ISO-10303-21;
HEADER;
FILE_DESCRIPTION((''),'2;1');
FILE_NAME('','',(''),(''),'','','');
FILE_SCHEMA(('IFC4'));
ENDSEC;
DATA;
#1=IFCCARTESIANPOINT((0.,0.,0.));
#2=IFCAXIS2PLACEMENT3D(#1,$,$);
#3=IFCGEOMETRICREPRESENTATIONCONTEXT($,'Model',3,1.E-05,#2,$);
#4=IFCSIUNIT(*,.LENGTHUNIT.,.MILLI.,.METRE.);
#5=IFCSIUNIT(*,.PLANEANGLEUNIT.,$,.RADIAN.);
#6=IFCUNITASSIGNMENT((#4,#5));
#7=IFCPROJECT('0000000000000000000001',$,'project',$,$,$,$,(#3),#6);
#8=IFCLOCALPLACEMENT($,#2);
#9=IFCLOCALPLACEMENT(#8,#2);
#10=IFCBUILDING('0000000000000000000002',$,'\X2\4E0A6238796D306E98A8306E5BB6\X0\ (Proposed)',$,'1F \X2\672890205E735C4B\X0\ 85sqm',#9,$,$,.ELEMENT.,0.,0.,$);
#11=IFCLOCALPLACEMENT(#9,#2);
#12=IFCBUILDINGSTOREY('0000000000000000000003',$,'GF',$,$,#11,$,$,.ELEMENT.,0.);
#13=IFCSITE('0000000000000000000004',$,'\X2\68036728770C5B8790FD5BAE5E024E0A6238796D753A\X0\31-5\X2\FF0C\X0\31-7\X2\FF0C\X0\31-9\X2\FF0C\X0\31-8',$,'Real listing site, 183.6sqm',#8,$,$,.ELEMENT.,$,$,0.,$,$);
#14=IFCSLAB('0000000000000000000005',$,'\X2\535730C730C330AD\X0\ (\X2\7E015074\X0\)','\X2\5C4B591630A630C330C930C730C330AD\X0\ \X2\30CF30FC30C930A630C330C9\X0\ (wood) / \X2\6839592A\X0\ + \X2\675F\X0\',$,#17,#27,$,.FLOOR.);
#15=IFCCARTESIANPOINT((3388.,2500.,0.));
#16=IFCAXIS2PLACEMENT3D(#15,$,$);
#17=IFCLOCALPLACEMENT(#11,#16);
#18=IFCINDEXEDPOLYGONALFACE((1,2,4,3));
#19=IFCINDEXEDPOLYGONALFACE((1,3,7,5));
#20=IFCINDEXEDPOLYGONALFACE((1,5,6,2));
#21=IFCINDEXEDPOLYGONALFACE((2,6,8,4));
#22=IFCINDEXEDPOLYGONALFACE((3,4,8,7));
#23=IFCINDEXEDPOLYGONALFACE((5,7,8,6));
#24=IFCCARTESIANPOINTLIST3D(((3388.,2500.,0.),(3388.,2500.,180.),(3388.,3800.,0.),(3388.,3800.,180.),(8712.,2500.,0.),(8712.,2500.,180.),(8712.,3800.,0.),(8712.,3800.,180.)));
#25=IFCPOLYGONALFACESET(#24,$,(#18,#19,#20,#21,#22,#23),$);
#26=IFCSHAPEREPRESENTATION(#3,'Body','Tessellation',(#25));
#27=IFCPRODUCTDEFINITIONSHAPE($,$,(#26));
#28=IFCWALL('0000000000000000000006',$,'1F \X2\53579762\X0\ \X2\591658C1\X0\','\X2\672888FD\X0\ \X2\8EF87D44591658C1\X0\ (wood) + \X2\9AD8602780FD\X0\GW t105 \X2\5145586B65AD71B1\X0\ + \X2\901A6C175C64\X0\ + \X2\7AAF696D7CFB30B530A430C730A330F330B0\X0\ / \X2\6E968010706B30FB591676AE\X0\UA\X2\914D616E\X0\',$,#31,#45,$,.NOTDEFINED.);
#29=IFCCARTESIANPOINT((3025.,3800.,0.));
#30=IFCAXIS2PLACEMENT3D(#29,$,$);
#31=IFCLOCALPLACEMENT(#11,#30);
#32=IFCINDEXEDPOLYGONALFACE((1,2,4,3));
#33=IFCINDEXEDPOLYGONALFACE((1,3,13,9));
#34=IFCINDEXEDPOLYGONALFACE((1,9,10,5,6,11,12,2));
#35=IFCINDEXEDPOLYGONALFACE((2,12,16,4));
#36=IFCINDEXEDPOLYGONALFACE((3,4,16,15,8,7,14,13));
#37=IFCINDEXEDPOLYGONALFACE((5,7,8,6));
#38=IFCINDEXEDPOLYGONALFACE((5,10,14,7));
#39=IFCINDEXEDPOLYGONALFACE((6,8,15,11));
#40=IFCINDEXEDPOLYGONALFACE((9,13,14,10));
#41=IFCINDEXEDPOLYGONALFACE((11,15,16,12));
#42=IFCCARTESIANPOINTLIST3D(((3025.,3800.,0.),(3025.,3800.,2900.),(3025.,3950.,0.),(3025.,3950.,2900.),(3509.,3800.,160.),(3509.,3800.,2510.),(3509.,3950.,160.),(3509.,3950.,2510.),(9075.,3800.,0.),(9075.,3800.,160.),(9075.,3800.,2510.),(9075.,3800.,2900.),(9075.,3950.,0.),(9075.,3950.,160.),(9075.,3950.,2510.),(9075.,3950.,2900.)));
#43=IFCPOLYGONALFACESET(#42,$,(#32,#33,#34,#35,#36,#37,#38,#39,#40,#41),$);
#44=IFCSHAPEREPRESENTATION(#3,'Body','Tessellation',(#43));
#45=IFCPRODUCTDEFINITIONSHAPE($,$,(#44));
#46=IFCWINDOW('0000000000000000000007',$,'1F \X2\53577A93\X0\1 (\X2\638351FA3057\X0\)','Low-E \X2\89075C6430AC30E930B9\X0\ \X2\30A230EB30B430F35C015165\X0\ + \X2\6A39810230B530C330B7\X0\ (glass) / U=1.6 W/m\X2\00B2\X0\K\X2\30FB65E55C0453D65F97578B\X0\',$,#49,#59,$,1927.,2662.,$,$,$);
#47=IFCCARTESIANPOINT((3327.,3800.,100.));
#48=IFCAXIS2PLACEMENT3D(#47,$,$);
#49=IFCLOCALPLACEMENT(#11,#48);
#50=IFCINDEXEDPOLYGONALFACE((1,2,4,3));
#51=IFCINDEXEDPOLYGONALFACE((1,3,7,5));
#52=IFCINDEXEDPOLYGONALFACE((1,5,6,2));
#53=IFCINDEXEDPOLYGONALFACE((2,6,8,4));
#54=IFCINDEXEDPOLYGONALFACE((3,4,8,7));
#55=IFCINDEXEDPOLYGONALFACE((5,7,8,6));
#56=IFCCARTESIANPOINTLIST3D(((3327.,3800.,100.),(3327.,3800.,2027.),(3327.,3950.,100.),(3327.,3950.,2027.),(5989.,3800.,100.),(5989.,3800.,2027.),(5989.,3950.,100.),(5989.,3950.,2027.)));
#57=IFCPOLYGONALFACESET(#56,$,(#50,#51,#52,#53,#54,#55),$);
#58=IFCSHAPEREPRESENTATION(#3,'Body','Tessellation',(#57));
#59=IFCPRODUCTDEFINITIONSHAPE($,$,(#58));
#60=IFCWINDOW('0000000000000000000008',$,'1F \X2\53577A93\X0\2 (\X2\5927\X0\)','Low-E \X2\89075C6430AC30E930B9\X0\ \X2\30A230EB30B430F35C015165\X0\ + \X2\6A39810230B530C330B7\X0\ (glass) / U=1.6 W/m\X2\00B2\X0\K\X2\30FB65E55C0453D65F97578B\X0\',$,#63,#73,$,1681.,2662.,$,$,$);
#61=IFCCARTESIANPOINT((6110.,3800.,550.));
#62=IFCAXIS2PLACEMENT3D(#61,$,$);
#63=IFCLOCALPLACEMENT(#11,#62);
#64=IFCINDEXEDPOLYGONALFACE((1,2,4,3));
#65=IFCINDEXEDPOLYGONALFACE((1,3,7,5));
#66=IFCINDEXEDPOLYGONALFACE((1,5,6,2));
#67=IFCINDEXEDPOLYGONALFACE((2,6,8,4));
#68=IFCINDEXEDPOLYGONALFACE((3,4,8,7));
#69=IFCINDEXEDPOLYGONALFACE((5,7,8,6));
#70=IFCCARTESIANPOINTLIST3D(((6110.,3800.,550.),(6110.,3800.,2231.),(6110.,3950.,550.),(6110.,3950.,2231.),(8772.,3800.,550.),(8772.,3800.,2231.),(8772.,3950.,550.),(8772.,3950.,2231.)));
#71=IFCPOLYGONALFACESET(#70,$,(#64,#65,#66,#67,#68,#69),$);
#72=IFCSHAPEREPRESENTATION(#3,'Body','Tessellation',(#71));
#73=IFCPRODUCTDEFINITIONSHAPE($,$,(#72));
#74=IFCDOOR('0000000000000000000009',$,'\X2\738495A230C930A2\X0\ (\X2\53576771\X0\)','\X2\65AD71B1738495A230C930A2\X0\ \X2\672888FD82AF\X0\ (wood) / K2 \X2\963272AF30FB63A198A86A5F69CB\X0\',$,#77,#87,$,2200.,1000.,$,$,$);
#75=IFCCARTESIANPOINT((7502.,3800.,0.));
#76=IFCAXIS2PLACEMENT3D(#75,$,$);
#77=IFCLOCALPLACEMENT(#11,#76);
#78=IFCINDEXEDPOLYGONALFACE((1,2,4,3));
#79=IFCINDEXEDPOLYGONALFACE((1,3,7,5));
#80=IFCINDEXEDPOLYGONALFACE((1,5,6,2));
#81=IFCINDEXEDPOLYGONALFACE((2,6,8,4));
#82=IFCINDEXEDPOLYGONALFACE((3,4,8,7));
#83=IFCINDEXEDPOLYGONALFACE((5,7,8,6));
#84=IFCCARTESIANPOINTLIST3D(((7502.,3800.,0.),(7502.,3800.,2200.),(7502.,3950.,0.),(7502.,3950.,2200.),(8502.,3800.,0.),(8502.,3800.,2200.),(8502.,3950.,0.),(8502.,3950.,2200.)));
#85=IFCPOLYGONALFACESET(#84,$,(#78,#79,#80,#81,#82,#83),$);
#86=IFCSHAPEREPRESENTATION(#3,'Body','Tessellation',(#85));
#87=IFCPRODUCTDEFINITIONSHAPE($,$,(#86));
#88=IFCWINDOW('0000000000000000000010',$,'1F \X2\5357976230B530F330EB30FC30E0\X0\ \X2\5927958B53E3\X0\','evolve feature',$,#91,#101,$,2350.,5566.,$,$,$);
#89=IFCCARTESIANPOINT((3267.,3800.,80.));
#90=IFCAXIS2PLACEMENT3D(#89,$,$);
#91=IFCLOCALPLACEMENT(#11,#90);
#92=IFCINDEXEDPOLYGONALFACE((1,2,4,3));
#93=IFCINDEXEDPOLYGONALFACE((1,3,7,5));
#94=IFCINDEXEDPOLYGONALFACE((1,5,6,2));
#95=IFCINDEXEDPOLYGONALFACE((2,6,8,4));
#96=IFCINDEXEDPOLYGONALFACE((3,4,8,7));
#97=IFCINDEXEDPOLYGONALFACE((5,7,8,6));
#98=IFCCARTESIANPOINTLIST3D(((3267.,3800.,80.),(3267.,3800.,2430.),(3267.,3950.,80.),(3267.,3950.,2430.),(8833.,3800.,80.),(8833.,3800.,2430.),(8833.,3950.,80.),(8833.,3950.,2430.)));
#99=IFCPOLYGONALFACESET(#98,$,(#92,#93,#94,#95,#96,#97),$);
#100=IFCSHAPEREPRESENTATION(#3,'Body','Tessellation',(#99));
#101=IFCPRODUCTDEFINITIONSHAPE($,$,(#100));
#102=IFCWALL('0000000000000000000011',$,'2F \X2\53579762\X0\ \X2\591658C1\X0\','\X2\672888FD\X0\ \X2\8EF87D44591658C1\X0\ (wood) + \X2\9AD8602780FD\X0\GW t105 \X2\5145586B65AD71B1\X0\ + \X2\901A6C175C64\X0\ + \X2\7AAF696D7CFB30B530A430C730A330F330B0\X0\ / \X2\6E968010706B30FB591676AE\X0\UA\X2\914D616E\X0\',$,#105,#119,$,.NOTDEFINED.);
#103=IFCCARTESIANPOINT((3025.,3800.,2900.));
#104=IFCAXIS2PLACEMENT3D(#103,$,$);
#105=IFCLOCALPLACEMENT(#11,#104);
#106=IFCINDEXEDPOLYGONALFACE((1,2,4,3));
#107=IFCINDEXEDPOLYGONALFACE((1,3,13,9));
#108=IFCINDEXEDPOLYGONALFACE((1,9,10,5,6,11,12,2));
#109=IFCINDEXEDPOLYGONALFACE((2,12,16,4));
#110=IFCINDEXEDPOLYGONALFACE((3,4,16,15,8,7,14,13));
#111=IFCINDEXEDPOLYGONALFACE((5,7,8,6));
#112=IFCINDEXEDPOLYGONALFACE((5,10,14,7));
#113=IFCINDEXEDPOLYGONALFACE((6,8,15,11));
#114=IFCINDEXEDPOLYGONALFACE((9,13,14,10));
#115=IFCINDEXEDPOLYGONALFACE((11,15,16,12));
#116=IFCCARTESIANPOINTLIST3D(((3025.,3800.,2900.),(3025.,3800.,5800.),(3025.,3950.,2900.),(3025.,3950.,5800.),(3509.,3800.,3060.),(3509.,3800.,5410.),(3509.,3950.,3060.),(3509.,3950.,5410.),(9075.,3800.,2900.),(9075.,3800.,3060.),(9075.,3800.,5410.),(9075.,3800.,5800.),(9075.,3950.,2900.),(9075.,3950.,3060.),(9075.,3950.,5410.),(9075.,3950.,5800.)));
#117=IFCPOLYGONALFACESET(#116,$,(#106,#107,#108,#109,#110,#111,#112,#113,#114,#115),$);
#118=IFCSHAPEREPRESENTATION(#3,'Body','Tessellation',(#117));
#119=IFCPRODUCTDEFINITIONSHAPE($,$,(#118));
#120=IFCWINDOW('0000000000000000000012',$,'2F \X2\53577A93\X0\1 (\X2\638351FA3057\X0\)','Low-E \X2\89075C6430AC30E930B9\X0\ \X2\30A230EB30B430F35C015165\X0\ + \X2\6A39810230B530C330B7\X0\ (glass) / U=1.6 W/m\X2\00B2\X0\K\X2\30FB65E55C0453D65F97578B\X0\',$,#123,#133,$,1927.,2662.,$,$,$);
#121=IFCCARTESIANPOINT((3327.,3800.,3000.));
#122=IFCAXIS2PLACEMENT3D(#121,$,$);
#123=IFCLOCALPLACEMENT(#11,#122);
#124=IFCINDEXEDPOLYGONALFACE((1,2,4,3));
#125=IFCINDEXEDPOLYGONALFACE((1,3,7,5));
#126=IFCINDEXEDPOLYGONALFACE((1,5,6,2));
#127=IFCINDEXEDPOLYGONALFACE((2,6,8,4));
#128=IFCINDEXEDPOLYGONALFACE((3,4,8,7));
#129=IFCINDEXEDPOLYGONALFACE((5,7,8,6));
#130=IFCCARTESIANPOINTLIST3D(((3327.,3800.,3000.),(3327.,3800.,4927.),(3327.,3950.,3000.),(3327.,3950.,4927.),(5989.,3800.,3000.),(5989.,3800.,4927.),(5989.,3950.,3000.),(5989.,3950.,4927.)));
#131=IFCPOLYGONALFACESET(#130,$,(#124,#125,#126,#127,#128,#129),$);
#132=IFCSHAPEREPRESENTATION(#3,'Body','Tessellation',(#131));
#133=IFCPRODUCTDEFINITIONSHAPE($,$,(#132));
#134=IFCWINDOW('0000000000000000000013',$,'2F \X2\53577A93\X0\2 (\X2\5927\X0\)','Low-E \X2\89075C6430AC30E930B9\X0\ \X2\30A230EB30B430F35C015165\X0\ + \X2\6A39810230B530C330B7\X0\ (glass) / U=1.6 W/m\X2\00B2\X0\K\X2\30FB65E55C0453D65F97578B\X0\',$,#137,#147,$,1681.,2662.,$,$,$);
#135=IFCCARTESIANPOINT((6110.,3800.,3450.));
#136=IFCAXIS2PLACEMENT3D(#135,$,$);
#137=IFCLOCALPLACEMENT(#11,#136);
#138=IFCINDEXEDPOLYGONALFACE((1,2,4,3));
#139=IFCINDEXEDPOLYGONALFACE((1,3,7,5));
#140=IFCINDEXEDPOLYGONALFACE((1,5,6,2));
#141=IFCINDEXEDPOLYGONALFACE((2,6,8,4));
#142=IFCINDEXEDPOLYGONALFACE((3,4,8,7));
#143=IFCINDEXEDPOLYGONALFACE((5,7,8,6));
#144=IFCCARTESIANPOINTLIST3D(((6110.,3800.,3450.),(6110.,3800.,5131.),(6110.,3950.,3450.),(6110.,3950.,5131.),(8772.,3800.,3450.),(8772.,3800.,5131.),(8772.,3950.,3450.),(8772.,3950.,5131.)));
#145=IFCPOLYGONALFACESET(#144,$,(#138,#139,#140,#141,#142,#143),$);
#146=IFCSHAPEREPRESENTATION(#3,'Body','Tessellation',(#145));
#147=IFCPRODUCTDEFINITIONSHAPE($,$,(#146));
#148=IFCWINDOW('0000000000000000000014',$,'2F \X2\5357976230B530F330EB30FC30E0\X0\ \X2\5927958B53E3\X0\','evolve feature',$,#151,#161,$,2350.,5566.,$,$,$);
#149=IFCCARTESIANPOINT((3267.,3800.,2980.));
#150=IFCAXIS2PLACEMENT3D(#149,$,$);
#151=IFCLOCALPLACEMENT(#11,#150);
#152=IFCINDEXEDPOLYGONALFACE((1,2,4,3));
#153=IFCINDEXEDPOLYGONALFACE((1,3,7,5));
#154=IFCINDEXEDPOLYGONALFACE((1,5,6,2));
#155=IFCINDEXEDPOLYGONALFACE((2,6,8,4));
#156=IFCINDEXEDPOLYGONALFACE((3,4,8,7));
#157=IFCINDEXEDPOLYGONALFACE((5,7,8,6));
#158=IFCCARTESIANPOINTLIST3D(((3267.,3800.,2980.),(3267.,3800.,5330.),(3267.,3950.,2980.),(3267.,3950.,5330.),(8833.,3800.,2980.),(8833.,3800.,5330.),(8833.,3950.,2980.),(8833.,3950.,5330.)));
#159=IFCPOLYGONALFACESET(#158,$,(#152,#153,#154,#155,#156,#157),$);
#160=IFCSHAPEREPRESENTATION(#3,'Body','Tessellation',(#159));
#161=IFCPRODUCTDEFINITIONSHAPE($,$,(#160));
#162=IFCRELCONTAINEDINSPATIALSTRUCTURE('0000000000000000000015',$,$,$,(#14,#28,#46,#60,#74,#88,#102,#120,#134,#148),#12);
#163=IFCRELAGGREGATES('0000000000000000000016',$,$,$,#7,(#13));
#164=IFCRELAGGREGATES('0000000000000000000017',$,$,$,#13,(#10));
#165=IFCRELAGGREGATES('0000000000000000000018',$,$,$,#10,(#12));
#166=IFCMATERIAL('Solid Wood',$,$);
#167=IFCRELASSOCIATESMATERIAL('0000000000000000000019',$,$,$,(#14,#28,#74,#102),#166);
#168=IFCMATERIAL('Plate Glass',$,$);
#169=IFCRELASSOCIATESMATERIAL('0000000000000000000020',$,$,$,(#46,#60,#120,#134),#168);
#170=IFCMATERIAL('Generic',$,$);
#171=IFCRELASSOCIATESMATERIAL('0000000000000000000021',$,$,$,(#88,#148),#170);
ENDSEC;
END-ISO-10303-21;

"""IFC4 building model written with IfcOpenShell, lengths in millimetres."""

from ifc_helpers import new_model, si_unit, frame, frame_2d, origin, place, context, project, spatial, rectangle, extrude, material, element, fill, save


model = new_model("IFC4")

# Units and contexts
model_context = context("Model", 3, precision=1e-05, world=origin())
ifc_project = project(units=[si_unit("LENGTHUNIT", "METRE", prefix="MILLI"), si_unit("PLANEANGLEUNIT", "RADIAN")], contexts=[model_context])

# Site, building, storey
site_placement = place(None, origin())
site = spatial("IfcSite", under=ifc_project, at=site_placement, Name="栃木県宇都宮市上戸祭町31-5，31-7，31-9，31-8", ObjectType="Real listing site, 183.6sqm", CompositionType="ELEMENT", RefElevation=0.0)
building_placement = place(site_placement, origin())
building = spatial("IfcBuilding", under=site, at=building_placement, Name="上戸祭の風の家 (Proposed)", ObjectType="1F 木造平屋 85sqm", CompositionType="ELEMENT", ElevationOfRefHeight=0.0, ElevationOfTerrain=0.0)
storey_placement = place(building_placement, origin())
storey = spatial("IfcBuildingStorey", under=building, at=storey_placement, Name="GF", CompositionType="ELEMENT", Elevation=0.0)

# Slab
ifc_material_1 = material(Name="Solid Wood")
slab_1_placement = place(storey_placement, frame((3388.0, 2500.0, 0.0)))
element("IfcSlab", 1, at=slab_1_placement, inside=storey, material=ifc_material_1, Name="南デッキ (縁側)", Description="屋外ウッドデッキ ハードウッド (wood) / 根太 + 束", PredefinedType="FLOOR", context=model_context, shape_type="SweptSolid", body=[
    extrude(rectangle(XDim=5324.0, YDim=1300.0, at=frame_2d((2662.0, 650.0))), frame((3388.0, 2500.0, 0.0)), (0.0, 0.0, 1.0), 180.0),
])
ifc_material_2 = material(Name="Generic")

# Wall, openings, windows, door
wall_1_placement = place(storey_placement, frame((3025.0, 3800.0, 0.0)))
wall_1 = element("IfcWall", 2, at=wall_1_placement, inside=storey, material=ifc_material_1, Name="1F 南面 外壁", Description="木製 軸組外壁 (wood) + 高性能GW t105 充填断熱 + 通気層 + 窯業系サイディング / 準耐火・外皮UA配慮", PredefinedType="NOTDEFINED", context=model_context, shape_type="SweptSolid", body=[
    extrude(rectangle(XDim=6050.0, YDim=150.0, at=frame_2d((3025.0, 75.0))), frame((3025.0, 3800.0, 0.0)), (0.0, 0.0, 1.0), 2900.0),
])
opening_1_placement = place(storey_placement, frame((3327.0, 3800.0, 100.0)))
opening_1 = element("IfcOpeningElement", 3, at=opening_1_placement, cuts=wall_1, PredefinedType="NOTDEFINED", context=model_context, shape_type="SweptSolid", body=[
    extrude(rectangle(XDim=2662.0, YDim=150.0, at=frame_2d((1331.0, 75.0))), frame((3327.0, 3800.0, 100.0)), (0.0, 0.0, 1.0), 1927.0),
])
opening_2_placement = place(storey_placement, frame((6110.0, 3800.0, 550.0)))
opening_2 = element("IfcOpeningElement", 4, at=opening_2_placement, cuts=wall_1, PredefinedType="NOTDEFINED", context=model_context, shape_type="SweptSolid", body=[
    extrude(rectangle(XDim=2662.0, YDim=150.0, at=frame_2d((1331.0, 75.0))), frame((6110.0, 3800.0, 550.0)), (0.0, 0.0, 1.0), 1681.0),
])
opening_3_placement = place(storey_placement, frame((7502.0, 3800.0, 0.0)))
opening_3 = element("IfcOpeningElement", 5, at=opening_3_placement, cuts=wall_1, PredefinedType="NOTDEFINED", context=model_context, shape_type="SweptSolid", body=[
    extrude(rectangle(XDim=1000.0, YDim=150.0, at=frame_2d((500.0, 75.0))), frame((7502.0, 3800.0, 0.0)), (0.0, 0.0, 1.0), 2200.0),
])
opening_4_placement = place(storey_placement, frame((3267.0, 3800.0, 80.0)))
opening_4 = element("IfcOpeningElement", 6, at=opening_4_placement, cuts=wall_1, PredefinedType="NOTDEFINED", context=model_context, shape_type="SweptSolid", body=[
    extrude(rectangle(XDim=5566.0, YDim=150.0, at=frame_2d((2783.0, 75.0))), frame((3267.0, 3800.0, 80.0)), (0.0, 0.0, 1.0), 2350.0),
])
ifc_material_3 = material(Name="Plate Glass")
window_1_placement = place(storey_placement, frame((3327.0, 3800.0, 100.0)))
window_1 = element("IfcWindow", 7, at=window_1_placement, inside=storey, material=ifc_material_3, Name="1F 南窓1 (掃出し)", Description="Low-E 複層ガラス アルゴン封入 + 樹脂サッシ (glass) / U=1.6 W/m²K・日射取得型", OverallHeight=1927.0, OverallWidth=2662.0, context=model_context, shape_type="SweptSolid", body=[
    extrude(rectangle(XDim=2662.0, YDim=150.0, at=frame_2d((1331.0, 75.0))), frame((3327.0, 3800.0, 100.0)), (0.0, 0.0, 1.0), 1927.0),
])
fill(opening_1, window_1)
window_2_placement = place(storey_placement, frame((6110.0, 3800.0, 550.0)))
window_2 = element("IfcWindow", 8, at=window_2_placement, inside=storey, material=ifc_material_3, Name="1F 南窓2 (大)", Description="Low-E 複層ガラス アルゴン封入 + 樹脂サッシ (glass) / U=1.6 W/m²K・日射取得型", OverallHeight=1681.0, OverallWidth=2662.0, context=model_context, shape_type="SweptSolid", body=[
    extrude(rectangle(XDim=2662.0, YDim=150.0, at=frame_2d((1331.0, 75.0))), frame((6110.0, 3800.0, 550.0)), (0.0, 0.0, 1.0), 1681.0),
])
fill(opening_2, window_2)
door_placement = place(storey_placement, frame((7502.0, 3800.0, 0.0)))
door = element("IfcDoor", 9, at=door_placement, inside=storey, material=ifc_material_1, Name="玄関ドア (南東)", Description="断熱玄関ドア 木製芯 (wood) / K2 防犯・採風機構", OverallHeight=2200.0, OverallWidth=1000.0, context=model_context, shape_type="SweptSolid", body=[
    extrude(rectangle(XDim=1000.0, YDim=150.0, at=frame_2d((500.0, 75.0))), frame((7502.0, 3800.0, 0.0)), (0.0, 0.0, 1.0), 2200.0),
])
fill(opening_3, door)
window_3_placement = place(storey_placement, frame((3267.0, 3800.0, 80.0)))
window_3 = element("IfcWindow", 10, at=window_3_placement, inside=storey, material=ifc_material_2, Name="1F 南面サンルーム 大開口", Description="evolve feature", OverallHeight=2350.0, OverallWidth=5566.0, context=model_context, shape_type="SweptSolid", body=[
    extrude(rectangle(XDim=5566.0, YDim=150.0, at=frame_2d((2783.0, 75.0))), frame((3267.0, 3800.0, 80.0)), (0.0, 0.0, 1.0), 2350.0),
])
fill(opening_4, window_3)

# Wall, openings, windows
wall_2_placement = place(storey_placement, frame((3025.0, 3800.0, 2900.0)))
wall_2 = element("IfcWall", 11, at=wall_2_placement, inside=storey, material=ifc_material_1, Name="2F 南面 外壁", Description="木製 軸組外壁 (wood) + 高性能GW t105 充填断熱 + 通気層 + 窯業系サイディング / 準耐火・外皮UA配慮", PredefinedType="NOTDEFINED", context=model_context, shape_type="SweptSolid", body=[
    extrude(rectangle(XDim=6050.0, YDim=150.0, at=frame_2d((3025.0, 75.0))), frame((3025.0, 3800.0, 2900.0)), (0.0, 0.0, 1.0), 2900.0),
])
opening_5_placement = place(storey_placement, frame((3327.0, 3800.0, 3000.0)))
opening_5 = element("IfcOpeningElement", 12, at=opening_5_placement, cuts=wall_2, PredefinedType="NOTDEFINED", context=model_context, shape_type="SweptSolid", body=[
    extrude(rectangle(XDim=2662.0, YDim=150.0, at=frame_2d((1331.0, 75.0))), frame((3327.0, 3800.0, 3000.0)), (0.0, 0.0, 1.0), 1927.0),
])
opening_6_placement = place(storey_placement, frame((6110.0, 3800.0, 3450.0)))
opening_6 = element("IfcOpeningElement", 13, at=opening_6_placement, cuts=wall_2, PredefinedType="NOTDEFINED", context=model_context, shape_type="SweptSolid", body=[
    extrude(rectangle(XDim=2662.0, YDim=150.0, at=frame_2d((1331.0, 75.0))), frame((6110.0, 3800.0, 3450.0)), (0.0, 0.0, 1.0), 1681.0),
])
opening_7_placement = place(storey_placement, frame((3267.0, 3800.0, 2980.0)))
opening_7 = element("IfcOpeningElement", 14, at=opening_7_placement, cuts=wall_2, PredefinedType="NOTDEFINED", context=model_context, shape_type="SweptSolid", body=[
    extrude(rectangle(XDim=5566.0, YDim=150.0, at=frame_2d((2783.0, 75.0))), frame((3267.0, 3800.0, 2980.0)), (0.0, 0.0, 1.0), 2350.0),
])
window_4_placement = place(storey_placement, frame((3327.0, 3800.0, 3000.0)))
window_4 = element("IfcWindow", 15, at=window_4_placement, inside=storey, material=ifc_material_3, Name="2F 南窓1 (掃出し)", Description="Low-E 複層ガラス アルゴン封入 + 樹脂サッシ (glass) / U=1.6 W/m²K・日射取得型", OverallHeight=1927.0, OverallWidth=2662.0, context=model_context, shape_type="SweptSolid", body=[
    extrude(rectangle(XDim=2662.0, YDim=150.0, at=frame_2d((1331.0, 75.0))), frame((3327.0, 3800.0, 3000.0)), (0.0, 0.0, 1.0), 1927.0),
])
fill(opening_5, window_4)
window_5_placement = place(storey_placement, frame((6110.0, 3800.0, 3450.0)))
window_5 = element("IfcWindow", 16, at=window_5_placement, inside=storey, material=ifc_material_3, Name="2F 南窓2 (大)", Description="Low-E 複層ガラス アルゴン封入 + 樹脂サッシ (glass) / U=1.6 W/m²K・日射取得型", OverallHeight=1681.0, OverallWidth=2662.0, context=model_context, shape_type="SweptSolid", body=[
    extrude(rectangle(XDim=2662.0, YDim=150.0, at=frame_2d((1331.0, 75.0))), frame((6110.0, 3800.0, 3450.0)), (0.0, 0.0, 1.0), 1681.0),
])
fill(opening_6, window_5)
window_6_placement = place(storey_placement, frame((3267.0, 3800.0, 2980.0)))
window_6 = element("IfcWindow", 17, at=window_6_placement, inside=storey, material=ifc_material_2, Name="2F 南面サンルーム 大開口", Description="evolve feature", OverallHeight=2350.0, OverallWidth=5566.0, context=model_context, shape_type="SweptSolid", body=[
    extrude(rectangle(XDim=5566.0, YDim=150.0, at=frame_2d((2783.0, 75.0))), frame((3267.0, 3800.0, 2980.0)), (0.0, 0.0, 1.0), 2350.0),
])
fill(opening_7, window_6)

save(model, "model.ifc")
